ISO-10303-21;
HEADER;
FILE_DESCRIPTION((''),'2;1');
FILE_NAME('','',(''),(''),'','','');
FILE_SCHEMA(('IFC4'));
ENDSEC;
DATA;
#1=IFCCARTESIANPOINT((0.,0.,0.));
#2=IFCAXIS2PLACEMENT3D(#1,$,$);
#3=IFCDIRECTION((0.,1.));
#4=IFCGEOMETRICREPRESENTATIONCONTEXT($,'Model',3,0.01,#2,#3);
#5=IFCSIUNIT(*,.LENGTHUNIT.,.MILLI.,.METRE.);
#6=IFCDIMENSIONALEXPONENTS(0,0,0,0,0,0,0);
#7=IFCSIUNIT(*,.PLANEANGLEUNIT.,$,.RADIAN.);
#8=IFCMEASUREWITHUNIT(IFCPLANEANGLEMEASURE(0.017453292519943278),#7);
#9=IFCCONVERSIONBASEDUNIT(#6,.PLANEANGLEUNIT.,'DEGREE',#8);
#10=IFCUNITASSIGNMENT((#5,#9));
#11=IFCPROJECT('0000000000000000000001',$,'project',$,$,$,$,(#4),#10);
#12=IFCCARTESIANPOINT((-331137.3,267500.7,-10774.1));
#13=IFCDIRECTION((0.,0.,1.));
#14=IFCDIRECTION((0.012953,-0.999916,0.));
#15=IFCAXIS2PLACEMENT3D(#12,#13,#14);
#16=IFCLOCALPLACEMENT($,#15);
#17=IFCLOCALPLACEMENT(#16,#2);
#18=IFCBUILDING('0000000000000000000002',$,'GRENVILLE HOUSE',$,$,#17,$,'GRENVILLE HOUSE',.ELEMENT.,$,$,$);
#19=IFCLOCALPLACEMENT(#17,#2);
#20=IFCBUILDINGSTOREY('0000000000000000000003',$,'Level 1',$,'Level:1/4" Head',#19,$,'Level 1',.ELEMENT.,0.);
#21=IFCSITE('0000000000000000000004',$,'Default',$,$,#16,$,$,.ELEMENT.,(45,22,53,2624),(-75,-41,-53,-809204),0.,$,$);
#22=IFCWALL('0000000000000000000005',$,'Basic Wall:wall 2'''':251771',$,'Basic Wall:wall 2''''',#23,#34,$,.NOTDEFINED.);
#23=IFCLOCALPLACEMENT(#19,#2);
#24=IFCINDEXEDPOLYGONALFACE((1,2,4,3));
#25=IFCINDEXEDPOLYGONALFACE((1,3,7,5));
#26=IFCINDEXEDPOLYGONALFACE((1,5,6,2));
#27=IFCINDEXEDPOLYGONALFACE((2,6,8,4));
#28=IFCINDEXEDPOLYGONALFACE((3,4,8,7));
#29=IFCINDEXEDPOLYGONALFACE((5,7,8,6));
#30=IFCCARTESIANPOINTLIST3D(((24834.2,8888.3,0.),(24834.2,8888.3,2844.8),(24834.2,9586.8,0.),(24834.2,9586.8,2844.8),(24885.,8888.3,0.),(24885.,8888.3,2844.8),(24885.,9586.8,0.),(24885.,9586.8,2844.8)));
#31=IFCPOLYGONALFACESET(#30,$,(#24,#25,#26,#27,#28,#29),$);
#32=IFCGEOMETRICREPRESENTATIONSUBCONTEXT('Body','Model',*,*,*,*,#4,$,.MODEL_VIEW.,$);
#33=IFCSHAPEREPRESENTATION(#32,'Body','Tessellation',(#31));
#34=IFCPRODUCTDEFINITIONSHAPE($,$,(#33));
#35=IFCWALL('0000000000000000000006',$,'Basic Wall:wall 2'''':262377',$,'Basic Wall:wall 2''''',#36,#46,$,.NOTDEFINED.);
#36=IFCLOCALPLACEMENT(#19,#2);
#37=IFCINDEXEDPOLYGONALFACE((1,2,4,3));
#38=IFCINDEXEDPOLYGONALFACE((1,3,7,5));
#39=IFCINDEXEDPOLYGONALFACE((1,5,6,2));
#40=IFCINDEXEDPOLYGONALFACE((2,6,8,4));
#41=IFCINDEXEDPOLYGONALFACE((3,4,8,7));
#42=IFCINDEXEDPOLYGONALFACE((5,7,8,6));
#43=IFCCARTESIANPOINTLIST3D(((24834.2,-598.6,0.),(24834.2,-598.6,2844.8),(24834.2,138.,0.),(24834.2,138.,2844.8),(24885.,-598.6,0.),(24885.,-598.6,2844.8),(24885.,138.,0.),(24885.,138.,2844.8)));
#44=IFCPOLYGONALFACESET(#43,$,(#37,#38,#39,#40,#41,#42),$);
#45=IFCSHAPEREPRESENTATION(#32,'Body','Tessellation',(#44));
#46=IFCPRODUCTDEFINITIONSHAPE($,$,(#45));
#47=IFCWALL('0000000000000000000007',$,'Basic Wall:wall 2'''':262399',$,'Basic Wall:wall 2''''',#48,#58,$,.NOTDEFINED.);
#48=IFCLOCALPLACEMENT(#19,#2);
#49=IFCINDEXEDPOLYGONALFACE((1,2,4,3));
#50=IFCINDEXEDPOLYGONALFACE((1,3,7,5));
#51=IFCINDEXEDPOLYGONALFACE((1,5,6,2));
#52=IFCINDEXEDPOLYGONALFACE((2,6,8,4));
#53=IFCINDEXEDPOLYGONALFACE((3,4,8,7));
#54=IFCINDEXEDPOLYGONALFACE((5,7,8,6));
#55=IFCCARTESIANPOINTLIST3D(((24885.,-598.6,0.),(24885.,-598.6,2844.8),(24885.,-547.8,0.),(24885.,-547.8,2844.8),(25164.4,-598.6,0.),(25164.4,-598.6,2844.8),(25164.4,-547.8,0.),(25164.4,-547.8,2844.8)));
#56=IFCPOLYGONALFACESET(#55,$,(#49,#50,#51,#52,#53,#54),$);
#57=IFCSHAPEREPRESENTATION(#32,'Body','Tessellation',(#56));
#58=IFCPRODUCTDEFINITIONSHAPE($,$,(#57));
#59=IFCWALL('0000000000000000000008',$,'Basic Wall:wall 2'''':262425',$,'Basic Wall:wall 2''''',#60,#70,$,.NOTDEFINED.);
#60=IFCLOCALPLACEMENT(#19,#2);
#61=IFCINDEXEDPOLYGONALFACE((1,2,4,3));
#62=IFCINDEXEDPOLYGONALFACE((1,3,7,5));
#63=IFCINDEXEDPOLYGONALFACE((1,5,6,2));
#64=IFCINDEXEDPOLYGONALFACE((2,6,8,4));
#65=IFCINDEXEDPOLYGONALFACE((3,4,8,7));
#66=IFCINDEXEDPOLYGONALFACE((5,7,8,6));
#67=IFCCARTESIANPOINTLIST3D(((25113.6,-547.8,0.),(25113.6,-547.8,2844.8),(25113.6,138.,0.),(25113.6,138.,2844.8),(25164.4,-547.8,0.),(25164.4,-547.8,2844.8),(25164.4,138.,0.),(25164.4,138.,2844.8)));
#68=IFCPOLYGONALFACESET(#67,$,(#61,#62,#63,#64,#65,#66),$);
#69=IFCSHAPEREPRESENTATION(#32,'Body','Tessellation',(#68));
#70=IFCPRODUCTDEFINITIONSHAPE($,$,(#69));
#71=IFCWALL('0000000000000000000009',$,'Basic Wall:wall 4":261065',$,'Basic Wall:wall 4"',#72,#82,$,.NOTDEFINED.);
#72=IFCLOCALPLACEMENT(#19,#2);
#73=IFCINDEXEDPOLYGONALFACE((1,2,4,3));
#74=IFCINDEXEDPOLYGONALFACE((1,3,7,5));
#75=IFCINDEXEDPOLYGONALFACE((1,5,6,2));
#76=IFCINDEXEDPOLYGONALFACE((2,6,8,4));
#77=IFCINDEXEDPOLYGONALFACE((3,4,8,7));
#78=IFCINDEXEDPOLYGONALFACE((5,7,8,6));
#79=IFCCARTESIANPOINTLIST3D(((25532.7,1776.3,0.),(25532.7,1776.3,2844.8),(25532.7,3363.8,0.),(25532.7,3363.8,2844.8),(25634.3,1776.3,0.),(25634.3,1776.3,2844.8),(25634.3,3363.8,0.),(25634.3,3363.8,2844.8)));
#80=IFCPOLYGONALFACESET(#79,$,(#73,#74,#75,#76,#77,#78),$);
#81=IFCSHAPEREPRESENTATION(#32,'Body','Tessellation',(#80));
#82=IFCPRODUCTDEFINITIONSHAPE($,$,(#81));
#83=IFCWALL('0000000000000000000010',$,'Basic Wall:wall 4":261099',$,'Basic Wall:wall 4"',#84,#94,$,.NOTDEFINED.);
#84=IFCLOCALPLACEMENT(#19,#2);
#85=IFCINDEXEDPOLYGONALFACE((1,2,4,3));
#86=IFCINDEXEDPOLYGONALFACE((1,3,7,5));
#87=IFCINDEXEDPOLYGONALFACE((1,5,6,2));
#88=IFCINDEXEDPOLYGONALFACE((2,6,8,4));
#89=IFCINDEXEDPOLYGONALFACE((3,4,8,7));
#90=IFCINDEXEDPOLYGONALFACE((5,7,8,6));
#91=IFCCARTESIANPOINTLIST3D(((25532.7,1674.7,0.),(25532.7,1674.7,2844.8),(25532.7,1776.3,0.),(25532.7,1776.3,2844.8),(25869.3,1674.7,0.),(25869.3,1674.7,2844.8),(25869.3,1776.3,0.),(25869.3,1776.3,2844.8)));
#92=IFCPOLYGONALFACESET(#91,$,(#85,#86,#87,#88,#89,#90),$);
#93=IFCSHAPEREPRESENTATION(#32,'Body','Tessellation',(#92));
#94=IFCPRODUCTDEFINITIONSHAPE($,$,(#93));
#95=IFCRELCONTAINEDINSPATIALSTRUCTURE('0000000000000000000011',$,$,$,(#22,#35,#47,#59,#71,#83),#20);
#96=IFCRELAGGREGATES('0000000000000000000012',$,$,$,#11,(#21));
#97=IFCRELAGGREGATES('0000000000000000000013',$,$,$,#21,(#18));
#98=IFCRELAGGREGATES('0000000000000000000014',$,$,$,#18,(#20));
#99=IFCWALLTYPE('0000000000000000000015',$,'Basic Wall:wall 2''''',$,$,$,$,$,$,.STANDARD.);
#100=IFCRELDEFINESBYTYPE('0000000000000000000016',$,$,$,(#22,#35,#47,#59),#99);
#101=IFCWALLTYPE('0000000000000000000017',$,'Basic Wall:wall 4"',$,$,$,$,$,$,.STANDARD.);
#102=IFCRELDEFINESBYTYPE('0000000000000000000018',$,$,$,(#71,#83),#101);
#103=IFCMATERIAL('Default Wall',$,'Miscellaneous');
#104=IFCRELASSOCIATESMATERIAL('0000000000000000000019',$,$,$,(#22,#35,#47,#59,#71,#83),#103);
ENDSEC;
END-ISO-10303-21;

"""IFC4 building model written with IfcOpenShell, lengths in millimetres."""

from ifc_helpers import new_model, entity, si_unit, converted_unit, direction, frame, origin, place, context, subcontext, project, spatial, indexed_curve, outline, extrude, material, type_object, element, save


model = new_model("IFC4")

# Units and contexts
model_context = context("Model", 3, precision=0.01, world=origin(), true_north=direction((0.0, 1.0)))
body_context = subcontext(model_context, "Body", "Model", "MODEL_VIEW")
ifc_project = project(units=[si_unit("LENGTHUNIT", "METRE", prefix="MILLI"), converted_unit("PLANEANGLEUNIT", "DEGREE", entity("IfcPlaneAngleMeasure", 0.017453292519943278), si_unit("PLANEANGLEUNIT", "RADIAN"), dimensions=[0, 0, 0, 0, 0, 0, 0])], contexts=[model_context])

# Site, building, storey
site_placement = place(None, frame((-331137.3, 267500.7, -10774.1), z_axis=(0.0, 0.0, 1.0), x_axis=(0.012953, -0.999916, 0.0)))
site = spatial("IfcSite", under=ifc_project, at=site_placement, Name="Default", CompositionType="ELEMENT", RefLatitude=(45, 22, 53, 2624), RefLongitude=(-75, -41, -53, -809204), RefElevation=0.0)
building_placement = place(site_placement, origin())
building = spatial("IfcBuilding", under=site, at=building_placement, Name="GRENVILLE HOUSE", LongName="GRENVILLE HOUSE", CompositionType="ELEMENT")
storey_placement = place(building_placement, origin())
storey = spatial("IfcBuildingStorey", under=building, at=storey_placement, Name="Level 1", ObjectType="Level:1/4\" Head", LongName="Level 1", CompositionType="ELEMENT", Elevation=0.0)

# Walls
ifc_material = material(Name="Default Wall", Category="Miscellaneous")
wall_type_1 = type_object("IfcWallType", Name="Basic Wall:wall 2''", PredefinedType="STANDARD")
wall_1_placement = place(storey_placement, frame((24859.6, 9586.8, 0.0), z_axis=(0.0, 0.0, 1.0), x_axis=(0.0, -1.0, 0.0)))
element("IfcWall", 1, at=wall_1_placement, inside=storey, type_object=wall_type_1, material=ifc_material, Name="Basic Wall:wall 2'':251771", ObjectType="Basic Wall:wall 2''", PredefinedType="NOTDEFINED", context=body_context, shape_type="SweptSolid", body=[
    extrude(outline(indexed_curve([(698.5, 25.4), (0.0, 25.4), (0.0, -25.4), (698.5, -25.4), (698.5, 25.4)], self_intersect=False)), origin(), (0.0, 0.0, 1.0), 2844.8),
])
wall_2_placement = place(storey_placement, frame((24859.6, 138.0, 0.0), z_axis=(0.0, 0.0, 1.0), x_axis=(0.0, -1.0, 0.0)))
element("IfcWall", 2, at=wall_2_placement, inside=storey, type_object=wall_type_1, material=ifc_material, Name="Basic Wall:wall 2'':262377", ObjectType="Basic Wall:wall 2''", PredefinedType="NOTDEFINED", context=body_context, shape_type="SweptSolid", body=[
    extrude(outline(indexed_curve([(736.6, 25.4), (0.0, 25.4), (0.0, -25.4), (736.6, -25.4), (736.6, 25.4)], self_intersect=False)), origin(), (0.0, 0.0, 1.0), 2844.8),
])
wall_3_placement = place(storey_placement, frame((24885.0, -573.2, 0.0)))
element("IfcWall", 3, at=wall_3_placement, inside=storey, type_object=wall_type_1, material=ifc_material, Name="Basic Wall:wall 2'':262399", ObjectType="Basic Wall:wall 2''", PredefinedType="NOTDEFINED", context=body_context, shape_type="SweptSolid", body=[
    extrude(outline(indexed_curve([(279.4, 25.4), (0.0, 25.4), (0.0, -25.4), (279.4, -25.4), (279.4, 25.4)], self_intersect=False)), origin(), (0.0, 0.0, 1.0), 2844.8),
])
wall_4_placement = place(storey_placement, frame((25139.0, -547.8, 0.0), z_axis=(0.0, 0.0, 1.0), x_axis=(0.0, 1.0, 0.0)))
element("IfcWall", 4, at=wall_4_placement, inside=storey, type_object=wall_type_1, material=ifc_material, Name="Basic Wall:wall 2'':262425", ObjectType="Basic Wall:wall 2''", PredefinedType="NOTDEFINED", context=body_context, shape_type="SweptSolid", body=[
    extrude(outline(indexed_curve([(685.8, 25.4), (0.0, 25.4), (0.0, -25.4), (685.8, -25.4), (685.8, 25.4)], self_intersect=False)), origin(), (0.0, 0.0, 1.0), 2844.8),
])
wall_type_2 = type_object("IfcWallType", Name="Basic Wall:wall 4\"", PredefinedType="STANDARD")
wall_5_placement = place(storey_placement, frame((25583.5, 1776.3, 0.0), z_axis=(0.0, 0.0, 1.0), x_axis=(0.0, 1.0, 0.0)))
element("IfcWall", 5, at=wall_5_placement, inside=storey, type_object=wall_type_2, material=ifc_material, Name="Basic Wall:wall 4\":261065", ObjectType="Basic Wall:wall 4\"", PredefinedType="NOTDEFINED", context=body_context, shape_type="SweptSolid", body=[
    extrude(outline(indexed_curve([(1587.5, 50.8), (0.0, 50.8), (0.0, -50.8), (1587.5, -50.8), (1587.5, 50.8)], self_intersect=False)), origin(), (0.0, 0.0, 1.0), 2844.8),
])
wall_6_placement = place(storey_placement, frame((25532.7, 1725.5, 0.0)))
element("IfcWall", 6, at=wall_6_placement, inside=storey, type_object=wall_type_2, material=ifc_material, Name="Basic Wall:wall 4\":261099", ObjectType="Basic Wall:wall 4\"", PredefinedType="NOTDEFINED", context=body_context, shape_type="SweptSolid", body=[
    extrude(outline(indexed_curve([(336.6, 50.8), (0.0, 50.8), (0.0, -50.8), (336.6, -50.8), (336.6, 50.8)], self_intersect=False)), origin(), (0.0, 0.0, 1.0), 2844.8),
])

save(model, "model.ifc")
